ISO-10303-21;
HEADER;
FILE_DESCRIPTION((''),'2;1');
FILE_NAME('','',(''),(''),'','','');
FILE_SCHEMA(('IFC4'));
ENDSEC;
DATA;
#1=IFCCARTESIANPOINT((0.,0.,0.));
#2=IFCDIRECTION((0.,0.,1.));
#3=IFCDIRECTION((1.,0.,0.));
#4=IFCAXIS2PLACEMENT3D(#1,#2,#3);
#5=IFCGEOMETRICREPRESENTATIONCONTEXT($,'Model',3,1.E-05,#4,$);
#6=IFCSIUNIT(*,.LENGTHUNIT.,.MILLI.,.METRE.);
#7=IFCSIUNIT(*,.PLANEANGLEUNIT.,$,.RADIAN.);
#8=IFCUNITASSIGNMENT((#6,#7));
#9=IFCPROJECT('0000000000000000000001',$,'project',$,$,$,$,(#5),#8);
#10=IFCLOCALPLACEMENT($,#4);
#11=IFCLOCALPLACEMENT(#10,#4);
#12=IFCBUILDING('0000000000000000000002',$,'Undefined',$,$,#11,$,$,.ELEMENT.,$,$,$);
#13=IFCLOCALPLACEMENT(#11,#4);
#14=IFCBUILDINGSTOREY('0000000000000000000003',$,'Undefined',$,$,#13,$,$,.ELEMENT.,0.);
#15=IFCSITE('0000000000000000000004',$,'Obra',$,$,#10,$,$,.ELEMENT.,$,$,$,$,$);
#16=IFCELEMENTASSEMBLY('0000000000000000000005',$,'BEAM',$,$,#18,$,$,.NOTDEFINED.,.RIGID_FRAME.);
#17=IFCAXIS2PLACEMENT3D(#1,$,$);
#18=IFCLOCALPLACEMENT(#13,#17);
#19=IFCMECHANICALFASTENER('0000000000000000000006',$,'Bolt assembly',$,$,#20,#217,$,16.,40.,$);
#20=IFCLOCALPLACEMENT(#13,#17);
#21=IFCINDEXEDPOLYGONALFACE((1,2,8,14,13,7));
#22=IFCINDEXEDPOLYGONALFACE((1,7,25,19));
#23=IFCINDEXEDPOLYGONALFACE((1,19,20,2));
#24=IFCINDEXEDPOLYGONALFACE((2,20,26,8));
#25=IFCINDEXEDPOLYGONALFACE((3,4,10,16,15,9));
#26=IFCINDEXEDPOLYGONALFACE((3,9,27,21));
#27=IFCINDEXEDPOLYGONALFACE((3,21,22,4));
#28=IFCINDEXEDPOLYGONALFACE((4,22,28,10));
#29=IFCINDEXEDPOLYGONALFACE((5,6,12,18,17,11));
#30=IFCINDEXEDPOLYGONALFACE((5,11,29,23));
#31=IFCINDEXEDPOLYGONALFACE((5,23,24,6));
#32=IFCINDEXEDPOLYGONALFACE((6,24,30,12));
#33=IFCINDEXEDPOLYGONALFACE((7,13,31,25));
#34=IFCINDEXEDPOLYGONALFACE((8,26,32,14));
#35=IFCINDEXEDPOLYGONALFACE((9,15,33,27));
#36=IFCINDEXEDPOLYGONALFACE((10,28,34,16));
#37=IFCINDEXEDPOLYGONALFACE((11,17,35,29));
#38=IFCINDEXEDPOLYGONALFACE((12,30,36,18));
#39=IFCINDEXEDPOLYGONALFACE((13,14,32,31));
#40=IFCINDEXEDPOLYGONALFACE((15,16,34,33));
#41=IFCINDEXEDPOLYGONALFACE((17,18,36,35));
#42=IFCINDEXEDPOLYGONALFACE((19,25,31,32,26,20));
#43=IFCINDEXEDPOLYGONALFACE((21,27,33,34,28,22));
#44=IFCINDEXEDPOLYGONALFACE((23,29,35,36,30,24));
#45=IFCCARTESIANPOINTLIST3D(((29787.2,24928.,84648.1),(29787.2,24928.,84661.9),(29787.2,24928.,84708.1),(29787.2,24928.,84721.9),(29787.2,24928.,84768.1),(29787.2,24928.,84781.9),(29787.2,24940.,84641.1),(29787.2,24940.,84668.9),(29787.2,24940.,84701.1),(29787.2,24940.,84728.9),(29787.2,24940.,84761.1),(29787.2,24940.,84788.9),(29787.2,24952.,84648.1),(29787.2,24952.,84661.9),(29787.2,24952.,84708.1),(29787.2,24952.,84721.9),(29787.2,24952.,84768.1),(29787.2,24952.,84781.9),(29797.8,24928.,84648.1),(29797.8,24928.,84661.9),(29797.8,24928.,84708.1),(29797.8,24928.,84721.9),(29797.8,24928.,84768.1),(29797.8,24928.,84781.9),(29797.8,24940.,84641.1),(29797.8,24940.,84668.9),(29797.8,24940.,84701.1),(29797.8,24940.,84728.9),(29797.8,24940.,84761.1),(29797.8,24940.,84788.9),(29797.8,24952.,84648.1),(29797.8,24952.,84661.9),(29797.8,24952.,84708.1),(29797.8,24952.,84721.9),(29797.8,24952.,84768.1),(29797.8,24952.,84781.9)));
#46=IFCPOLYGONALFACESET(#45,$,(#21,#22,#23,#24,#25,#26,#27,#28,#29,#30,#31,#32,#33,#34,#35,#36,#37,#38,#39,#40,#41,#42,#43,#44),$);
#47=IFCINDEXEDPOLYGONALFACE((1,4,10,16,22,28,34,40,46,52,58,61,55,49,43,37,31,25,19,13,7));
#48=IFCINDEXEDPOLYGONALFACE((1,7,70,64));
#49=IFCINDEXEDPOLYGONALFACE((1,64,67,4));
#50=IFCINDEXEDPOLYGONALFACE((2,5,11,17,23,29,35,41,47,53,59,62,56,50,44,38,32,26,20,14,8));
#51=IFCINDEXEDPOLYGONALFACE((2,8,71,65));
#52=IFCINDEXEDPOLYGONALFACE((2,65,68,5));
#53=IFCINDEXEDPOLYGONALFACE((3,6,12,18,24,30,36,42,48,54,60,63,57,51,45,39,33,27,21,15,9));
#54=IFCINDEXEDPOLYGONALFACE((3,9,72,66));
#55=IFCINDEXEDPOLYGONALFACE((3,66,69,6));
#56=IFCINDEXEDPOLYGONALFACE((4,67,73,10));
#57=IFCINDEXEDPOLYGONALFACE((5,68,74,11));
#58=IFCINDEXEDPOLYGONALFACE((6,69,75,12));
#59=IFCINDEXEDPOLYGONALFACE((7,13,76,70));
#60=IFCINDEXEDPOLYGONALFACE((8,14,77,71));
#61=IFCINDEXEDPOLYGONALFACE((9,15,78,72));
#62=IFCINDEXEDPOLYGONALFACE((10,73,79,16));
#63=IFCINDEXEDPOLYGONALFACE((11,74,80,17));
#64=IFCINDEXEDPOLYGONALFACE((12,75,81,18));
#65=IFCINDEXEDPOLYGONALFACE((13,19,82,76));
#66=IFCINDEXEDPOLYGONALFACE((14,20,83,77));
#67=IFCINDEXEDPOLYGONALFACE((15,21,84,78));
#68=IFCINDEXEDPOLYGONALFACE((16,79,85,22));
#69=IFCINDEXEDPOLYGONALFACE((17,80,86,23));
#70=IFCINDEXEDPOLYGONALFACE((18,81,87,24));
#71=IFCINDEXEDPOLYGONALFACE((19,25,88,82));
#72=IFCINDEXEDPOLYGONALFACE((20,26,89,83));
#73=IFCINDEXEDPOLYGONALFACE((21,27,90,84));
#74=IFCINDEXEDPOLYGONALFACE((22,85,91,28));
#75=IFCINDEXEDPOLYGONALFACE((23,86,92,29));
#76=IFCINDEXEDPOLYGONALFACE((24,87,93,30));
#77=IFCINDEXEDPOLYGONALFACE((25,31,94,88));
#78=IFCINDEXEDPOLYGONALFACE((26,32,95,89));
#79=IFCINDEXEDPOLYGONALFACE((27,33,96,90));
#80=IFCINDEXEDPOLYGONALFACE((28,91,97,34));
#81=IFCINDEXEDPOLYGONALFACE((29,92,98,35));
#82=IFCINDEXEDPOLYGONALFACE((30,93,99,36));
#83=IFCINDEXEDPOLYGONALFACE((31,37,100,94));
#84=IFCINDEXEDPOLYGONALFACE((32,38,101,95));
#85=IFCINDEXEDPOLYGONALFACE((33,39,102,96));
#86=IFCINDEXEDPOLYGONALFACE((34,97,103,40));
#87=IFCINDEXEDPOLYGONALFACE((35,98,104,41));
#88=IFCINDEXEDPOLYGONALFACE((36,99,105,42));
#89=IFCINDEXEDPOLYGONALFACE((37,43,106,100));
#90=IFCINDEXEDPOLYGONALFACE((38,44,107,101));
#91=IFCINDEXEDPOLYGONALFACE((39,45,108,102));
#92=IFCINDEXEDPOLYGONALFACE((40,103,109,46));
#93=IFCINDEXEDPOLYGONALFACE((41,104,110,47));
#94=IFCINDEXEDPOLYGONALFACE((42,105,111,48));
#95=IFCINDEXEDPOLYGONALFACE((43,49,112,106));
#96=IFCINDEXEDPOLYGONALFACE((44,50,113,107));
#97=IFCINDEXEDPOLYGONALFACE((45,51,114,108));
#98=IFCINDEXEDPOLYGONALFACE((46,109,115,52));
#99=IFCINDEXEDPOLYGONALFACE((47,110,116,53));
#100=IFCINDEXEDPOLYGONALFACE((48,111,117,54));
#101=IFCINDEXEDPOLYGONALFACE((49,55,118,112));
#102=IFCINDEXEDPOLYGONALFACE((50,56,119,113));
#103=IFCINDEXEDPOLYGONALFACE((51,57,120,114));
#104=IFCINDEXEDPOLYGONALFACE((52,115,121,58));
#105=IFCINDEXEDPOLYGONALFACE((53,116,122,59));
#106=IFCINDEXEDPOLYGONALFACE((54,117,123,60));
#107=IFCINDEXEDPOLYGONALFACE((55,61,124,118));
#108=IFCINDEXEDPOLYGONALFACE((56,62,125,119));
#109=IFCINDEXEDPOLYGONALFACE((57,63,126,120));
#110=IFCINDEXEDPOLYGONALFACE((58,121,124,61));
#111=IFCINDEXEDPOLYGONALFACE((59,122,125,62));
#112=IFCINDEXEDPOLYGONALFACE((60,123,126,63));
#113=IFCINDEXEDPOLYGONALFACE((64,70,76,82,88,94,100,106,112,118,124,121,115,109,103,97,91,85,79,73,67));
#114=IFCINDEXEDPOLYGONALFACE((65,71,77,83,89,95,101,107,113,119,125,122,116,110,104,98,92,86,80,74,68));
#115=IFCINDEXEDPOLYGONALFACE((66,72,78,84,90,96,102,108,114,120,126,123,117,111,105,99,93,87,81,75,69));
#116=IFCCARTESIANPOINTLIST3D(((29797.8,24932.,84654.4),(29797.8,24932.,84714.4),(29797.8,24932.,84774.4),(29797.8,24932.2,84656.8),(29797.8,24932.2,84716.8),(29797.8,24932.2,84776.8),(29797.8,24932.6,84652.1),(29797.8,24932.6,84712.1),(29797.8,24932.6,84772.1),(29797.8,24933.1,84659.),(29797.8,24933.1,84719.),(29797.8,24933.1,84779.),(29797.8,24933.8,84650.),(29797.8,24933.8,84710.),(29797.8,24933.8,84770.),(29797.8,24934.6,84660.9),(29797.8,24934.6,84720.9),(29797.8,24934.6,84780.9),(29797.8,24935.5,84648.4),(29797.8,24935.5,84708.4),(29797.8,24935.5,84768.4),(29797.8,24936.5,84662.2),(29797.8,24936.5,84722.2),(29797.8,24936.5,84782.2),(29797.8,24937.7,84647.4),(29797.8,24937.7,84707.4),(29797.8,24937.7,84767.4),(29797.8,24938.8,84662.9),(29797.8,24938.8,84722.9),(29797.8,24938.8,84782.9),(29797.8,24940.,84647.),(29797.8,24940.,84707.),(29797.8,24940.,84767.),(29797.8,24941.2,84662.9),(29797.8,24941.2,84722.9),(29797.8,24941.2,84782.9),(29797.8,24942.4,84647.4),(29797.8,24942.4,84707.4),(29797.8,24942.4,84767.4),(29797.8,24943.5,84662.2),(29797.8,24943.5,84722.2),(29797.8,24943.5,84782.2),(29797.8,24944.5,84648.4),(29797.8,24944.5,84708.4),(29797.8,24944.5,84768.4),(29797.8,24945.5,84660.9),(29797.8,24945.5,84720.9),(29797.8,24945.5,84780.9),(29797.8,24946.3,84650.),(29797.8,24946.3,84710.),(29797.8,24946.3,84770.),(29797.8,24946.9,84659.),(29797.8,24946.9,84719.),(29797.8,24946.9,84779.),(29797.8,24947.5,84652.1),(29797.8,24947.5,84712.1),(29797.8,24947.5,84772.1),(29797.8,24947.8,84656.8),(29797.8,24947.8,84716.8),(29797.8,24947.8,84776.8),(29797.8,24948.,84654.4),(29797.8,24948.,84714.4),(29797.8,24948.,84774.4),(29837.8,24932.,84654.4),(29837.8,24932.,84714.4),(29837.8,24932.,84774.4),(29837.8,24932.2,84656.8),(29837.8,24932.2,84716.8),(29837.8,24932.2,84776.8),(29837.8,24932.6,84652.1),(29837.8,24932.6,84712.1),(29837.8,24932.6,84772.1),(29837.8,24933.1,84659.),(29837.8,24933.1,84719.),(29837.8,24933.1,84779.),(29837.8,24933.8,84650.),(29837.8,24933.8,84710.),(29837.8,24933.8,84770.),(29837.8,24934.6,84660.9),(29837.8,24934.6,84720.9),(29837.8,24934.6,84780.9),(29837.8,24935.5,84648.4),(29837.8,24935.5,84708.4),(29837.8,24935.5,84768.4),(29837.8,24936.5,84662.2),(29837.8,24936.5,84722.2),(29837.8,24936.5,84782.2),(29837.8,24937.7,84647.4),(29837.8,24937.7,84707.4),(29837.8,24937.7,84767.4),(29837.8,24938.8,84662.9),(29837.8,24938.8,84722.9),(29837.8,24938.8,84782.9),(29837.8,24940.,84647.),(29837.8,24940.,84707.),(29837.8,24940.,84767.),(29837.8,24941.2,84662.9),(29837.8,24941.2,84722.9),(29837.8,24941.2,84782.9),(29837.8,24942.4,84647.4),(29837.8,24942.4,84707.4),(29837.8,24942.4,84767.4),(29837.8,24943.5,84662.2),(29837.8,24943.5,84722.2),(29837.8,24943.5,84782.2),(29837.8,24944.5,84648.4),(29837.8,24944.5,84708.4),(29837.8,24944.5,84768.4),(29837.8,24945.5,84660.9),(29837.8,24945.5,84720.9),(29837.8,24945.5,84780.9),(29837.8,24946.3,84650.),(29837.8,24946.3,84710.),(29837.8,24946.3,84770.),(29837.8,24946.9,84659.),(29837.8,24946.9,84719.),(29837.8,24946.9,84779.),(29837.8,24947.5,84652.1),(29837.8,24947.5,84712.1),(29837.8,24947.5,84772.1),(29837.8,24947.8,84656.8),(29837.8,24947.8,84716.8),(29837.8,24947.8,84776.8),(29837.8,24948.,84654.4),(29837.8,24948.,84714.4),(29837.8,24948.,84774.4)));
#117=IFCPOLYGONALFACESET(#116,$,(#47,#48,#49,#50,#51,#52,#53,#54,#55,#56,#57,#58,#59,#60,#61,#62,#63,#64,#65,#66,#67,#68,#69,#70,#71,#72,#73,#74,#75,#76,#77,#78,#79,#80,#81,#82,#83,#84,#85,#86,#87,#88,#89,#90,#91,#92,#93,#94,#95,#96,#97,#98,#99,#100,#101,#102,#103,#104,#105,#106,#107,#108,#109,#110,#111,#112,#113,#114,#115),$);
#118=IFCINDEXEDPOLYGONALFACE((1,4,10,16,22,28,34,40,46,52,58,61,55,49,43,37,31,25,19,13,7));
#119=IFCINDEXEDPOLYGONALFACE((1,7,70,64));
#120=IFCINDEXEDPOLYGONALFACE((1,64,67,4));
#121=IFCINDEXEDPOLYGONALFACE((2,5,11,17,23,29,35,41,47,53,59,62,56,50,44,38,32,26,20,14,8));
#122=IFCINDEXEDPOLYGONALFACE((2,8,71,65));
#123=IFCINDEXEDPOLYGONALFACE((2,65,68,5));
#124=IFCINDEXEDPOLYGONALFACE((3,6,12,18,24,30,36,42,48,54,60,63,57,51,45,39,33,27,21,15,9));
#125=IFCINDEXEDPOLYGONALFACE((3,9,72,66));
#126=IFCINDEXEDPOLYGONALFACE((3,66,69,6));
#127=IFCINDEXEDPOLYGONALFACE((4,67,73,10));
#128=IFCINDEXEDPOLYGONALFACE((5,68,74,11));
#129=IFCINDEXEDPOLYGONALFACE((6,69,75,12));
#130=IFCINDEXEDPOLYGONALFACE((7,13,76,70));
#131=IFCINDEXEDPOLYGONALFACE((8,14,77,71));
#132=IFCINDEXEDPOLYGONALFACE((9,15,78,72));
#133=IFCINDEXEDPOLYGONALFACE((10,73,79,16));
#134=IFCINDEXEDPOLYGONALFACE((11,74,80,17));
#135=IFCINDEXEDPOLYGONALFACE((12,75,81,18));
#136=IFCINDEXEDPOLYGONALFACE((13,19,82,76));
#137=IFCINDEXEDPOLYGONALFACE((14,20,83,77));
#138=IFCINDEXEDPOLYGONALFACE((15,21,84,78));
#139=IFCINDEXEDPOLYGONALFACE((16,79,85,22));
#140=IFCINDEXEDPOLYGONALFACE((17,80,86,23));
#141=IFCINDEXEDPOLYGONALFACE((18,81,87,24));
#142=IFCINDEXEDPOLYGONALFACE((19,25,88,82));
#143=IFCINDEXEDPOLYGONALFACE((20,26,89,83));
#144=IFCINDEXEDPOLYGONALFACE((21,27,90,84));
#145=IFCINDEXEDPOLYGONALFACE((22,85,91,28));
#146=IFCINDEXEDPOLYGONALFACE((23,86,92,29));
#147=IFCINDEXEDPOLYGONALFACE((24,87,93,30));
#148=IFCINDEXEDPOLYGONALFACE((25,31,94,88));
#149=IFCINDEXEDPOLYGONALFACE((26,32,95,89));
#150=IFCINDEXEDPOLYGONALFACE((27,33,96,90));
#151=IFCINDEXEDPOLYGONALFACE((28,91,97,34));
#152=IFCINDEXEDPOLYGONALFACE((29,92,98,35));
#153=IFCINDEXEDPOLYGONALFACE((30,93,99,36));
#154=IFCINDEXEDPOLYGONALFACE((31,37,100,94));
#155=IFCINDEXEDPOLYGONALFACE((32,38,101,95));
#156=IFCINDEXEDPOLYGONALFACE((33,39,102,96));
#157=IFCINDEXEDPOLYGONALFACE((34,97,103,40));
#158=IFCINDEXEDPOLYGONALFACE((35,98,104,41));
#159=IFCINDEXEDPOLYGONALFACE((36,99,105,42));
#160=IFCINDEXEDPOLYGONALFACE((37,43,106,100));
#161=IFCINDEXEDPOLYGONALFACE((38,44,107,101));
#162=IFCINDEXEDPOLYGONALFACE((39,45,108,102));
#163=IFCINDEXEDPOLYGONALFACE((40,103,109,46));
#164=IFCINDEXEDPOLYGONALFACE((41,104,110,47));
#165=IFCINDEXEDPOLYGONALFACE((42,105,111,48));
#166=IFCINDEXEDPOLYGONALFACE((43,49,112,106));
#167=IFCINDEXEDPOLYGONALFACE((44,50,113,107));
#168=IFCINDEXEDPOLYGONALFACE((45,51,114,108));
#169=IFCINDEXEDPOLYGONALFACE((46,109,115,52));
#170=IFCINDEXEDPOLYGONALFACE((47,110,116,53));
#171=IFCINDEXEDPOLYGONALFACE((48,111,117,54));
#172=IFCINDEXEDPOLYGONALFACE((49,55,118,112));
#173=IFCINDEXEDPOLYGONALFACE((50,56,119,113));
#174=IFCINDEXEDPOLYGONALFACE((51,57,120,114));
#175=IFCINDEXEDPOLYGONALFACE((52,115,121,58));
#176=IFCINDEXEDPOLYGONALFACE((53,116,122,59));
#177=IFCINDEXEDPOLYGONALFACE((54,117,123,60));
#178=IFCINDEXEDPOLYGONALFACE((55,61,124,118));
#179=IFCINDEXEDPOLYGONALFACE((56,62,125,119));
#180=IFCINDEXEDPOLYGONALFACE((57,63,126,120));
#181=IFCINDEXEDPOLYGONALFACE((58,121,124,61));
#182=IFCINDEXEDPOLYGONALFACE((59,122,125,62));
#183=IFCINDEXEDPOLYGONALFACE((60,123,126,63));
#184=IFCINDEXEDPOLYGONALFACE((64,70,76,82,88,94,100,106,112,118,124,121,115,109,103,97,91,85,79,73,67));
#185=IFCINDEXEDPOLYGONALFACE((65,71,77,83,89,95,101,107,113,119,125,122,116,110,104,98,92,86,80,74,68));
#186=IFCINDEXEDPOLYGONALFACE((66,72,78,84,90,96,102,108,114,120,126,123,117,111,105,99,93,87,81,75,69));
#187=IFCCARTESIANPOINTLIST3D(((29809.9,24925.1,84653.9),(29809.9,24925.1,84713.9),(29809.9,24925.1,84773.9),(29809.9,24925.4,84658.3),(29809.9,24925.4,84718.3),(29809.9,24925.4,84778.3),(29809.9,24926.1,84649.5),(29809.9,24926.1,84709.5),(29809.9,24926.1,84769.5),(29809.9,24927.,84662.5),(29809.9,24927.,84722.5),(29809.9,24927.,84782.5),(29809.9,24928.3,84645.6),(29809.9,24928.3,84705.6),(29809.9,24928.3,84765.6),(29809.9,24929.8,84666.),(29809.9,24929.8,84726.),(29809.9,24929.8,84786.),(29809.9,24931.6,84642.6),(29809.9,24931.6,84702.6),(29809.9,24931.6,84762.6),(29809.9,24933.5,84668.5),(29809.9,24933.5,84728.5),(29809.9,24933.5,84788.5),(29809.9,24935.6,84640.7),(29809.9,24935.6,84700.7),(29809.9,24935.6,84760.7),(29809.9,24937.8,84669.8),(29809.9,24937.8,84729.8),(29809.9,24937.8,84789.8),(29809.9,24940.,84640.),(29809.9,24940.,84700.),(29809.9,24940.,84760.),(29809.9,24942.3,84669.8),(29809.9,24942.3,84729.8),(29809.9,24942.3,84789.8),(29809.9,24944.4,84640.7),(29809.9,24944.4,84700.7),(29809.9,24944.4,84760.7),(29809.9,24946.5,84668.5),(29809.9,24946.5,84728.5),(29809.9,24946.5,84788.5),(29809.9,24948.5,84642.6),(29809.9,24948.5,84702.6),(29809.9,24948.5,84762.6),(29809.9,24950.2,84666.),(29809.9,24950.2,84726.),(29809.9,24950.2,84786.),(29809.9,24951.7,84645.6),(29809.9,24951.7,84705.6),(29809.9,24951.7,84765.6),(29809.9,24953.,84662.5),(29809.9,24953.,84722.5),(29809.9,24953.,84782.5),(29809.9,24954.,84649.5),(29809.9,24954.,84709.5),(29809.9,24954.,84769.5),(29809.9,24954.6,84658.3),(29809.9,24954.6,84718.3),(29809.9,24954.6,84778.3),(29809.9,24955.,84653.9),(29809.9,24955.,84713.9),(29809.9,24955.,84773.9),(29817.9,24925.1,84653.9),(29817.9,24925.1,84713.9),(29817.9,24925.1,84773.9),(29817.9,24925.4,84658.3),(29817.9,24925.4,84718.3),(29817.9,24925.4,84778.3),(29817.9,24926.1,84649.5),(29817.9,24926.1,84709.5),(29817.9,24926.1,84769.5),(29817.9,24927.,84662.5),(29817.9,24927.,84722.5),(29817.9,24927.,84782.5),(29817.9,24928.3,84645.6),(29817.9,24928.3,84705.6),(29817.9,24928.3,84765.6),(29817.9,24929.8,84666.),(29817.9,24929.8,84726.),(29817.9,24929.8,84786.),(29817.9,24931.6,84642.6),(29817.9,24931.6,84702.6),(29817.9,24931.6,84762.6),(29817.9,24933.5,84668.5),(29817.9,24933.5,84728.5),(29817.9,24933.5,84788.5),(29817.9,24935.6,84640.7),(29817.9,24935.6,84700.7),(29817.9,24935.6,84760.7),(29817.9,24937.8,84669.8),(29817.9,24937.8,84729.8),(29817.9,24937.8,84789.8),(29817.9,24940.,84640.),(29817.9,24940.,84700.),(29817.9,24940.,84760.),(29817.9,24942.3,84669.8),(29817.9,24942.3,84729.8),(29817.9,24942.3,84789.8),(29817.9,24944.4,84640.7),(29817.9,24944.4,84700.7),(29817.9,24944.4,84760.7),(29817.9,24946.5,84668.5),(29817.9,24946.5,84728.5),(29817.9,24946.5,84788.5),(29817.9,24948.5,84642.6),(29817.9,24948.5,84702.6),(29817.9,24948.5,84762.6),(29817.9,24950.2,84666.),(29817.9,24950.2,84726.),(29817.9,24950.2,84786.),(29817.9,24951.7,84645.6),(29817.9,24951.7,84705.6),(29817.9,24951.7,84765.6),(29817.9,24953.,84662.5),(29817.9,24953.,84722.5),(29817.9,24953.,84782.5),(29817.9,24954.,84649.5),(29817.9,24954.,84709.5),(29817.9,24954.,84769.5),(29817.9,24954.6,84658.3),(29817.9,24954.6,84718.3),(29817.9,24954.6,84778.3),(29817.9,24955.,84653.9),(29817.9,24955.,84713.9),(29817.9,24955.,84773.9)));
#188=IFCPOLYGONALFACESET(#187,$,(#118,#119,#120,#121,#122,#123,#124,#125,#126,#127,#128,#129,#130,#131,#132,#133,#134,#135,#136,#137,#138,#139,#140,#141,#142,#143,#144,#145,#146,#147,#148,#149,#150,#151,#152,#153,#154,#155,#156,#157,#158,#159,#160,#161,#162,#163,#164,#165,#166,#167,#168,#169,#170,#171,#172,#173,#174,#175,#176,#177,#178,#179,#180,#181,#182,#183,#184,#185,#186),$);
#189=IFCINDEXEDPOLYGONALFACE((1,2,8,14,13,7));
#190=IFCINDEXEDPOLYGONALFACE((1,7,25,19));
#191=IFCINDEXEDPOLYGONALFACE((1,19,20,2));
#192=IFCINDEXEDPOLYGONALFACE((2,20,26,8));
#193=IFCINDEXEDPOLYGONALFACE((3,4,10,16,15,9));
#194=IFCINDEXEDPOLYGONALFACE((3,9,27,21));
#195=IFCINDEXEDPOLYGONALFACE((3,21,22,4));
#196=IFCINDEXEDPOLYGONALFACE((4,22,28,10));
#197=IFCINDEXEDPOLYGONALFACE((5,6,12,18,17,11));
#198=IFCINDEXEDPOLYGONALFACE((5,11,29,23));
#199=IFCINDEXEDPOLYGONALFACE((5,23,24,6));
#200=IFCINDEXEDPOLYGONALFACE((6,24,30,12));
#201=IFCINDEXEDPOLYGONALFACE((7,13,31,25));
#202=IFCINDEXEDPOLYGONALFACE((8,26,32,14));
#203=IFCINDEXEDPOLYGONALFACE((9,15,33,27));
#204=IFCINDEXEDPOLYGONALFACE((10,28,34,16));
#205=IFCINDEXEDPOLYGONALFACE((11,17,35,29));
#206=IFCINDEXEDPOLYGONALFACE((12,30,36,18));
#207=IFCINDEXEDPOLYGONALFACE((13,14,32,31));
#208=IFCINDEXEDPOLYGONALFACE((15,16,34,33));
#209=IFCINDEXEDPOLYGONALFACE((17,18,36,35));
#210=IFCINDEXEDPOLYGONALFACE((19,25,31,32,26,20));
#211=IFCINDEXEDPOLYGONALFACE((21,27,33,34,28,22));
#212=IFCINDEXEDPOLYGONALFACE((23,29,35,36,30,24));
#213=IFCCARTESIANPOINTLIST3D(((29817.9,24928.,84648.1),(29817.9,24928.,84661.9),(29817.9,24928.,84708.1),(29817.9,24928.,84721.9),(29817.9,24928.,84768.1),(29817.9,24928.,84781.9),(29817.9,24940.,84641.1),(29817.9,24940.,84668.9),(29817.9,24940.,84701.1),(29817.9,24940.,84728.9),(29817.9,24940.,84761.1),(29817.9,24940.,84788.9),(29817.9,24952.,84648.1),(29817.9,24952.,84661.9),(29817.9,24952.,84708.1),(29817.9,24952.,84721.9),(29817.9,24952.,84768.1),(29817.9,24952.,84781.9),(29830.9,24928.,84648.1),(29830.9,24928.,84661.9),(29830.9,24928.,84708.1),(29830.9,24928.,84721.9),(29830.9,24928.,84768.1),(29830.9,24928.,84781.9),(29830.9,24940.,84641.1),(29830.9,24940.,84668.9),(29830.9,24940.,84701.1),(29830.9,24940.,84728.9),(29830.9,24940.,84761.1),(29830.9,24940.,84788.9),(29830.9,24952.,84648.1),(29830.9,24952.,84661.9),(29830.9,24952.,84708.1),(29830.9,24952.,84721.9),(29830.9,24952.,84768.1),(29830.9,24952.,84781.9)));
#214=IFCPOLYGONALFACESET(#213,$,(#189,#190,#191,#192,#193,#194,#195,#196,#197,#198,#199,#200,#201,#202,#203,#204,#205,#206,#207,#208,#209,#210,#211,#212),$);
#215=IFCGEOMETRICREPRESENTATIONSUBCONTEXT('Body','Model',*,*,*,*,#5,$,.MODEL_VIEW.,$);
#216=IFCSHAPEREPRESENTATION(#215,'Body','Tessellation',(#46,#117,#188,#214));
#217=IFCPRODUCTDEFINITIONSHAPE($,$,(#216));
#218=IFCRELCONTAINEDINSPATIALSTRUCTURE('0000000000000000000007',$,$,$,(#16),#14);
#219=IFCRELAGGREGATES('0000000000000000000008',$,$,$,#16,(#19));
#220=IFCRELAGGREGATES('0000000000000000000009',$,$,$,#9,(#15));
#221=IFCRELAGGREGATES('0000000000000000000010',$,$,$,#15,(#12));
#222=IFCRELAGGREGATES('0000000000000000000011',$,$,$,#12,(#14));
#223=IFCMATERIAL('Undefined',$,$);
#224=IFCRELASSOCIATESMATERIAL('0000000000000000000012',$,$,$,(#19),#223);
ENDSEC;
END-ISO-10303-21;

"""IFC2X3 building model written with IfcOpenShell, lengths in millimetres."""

from ifc_helpers import new_model, si_unit, frame, origin_with_axes, origin_2d_with_axis, place, context, subcontext, project, spatial, polyline, circle, outline, extrude, source, transform, mapped, material, element, aggregate, save


model = new_model("IFC2X3")

# Units and contexts
model_context = context("Model", 3, precision=1e-05, world=origin_with_axes())
body_context = subcontext(model_context, "Body", "Model", "MODEL_VIEW")
ifc_project = project(units=[si_unit("LENGTHUNIT", "METRE", prefix="MILLI"), si_unit("PLANEANGLEUNIT", "RADIAN")], contexts=[model_context])

# Site, building, storey
site_placement = place(None, origin_with_axes())
site = spatial("IfcSite", under=ifc_project, at=site_placement, Name="Obra", CompositionType="ELEMENT")
building_placement = place(site_placement, origin_with_axes())
building = spatial("IfcBuilding", under=site, at=building_placement, Name="Undefined", CompositionType="ELEMENT")
storey_placement = place(building_placement, origin_with_axes())
storey = spatial("IfcBuildingStorey", under=building, at=storey_placement, Name="Undefined", CompositionType="ELEMENT", Elevation=0.0)

# Shared definitions
ifc_material_1 = material(Name="Undefined")

# Element assembly
assembly_1_placement = place(storey_placement, origin_with_axes())
assembly_1 = element("IfcElementAssembly", 1, at=assembly_1_placement, inside=storey, Name="BEAM", AssemblyPlace="NOTDEFINED", PredefinedType="RIGID_FRAME")

# Mechanical fastener
shared_shape_1 = source(origin_with_axes(), body_context, "Body", "SweptSolid", [
    extrude(outline(polyline([(13.9, 0.0), (6.9, 12.0), (-6.9, 12.0), (-13.9, 0.0), (-6.9, -12.0), (6.9, -12.0), (13.9, 0.0)])), frame((0.0, -19.7, 0.0), z_axis=(0.0, 1.0, 0.0), x_axis=(1.0, 0.0, 0.0)), (0.0, 0.0, 1.0), 10.6),
    extrude(circle(Radius=8.0, at=origin_2d_with_axis()), frame((0.0, -9.1, 0.0), z_axis=(0.0, 1.0, 0.0), x_axis=(1.0, 0.0, 0.0)), (0.0, 0.0, 1.0), 40.0),
    extrude(circle(Radius=15.0, at=origin_2d_with_axis()), frame((0.0, 3.0, 0.0), z_axis=(0.0, 1.0, 0.0), x_axis=(1.0, 0.0, 0.0)), (0.0, 0.0, 1.0), 8.0),
    extrude(outline(polyline([(13.9, 0.0), (6.9, 12.0), (-6.9, 12.0), (-13.9, 0.0), (-6.9, -12.0), (6.9, -12.0), (13.9, 0.0)])), frame((0.0, 11.0, 0.0), z_axis=(0.0, 1.0, 0.0), x_axis=(1.0, 0.0, 0.0)), (0.0, 0.0, 1.0), 13.0),
])
mechanical_fastener_1_placement = place(assembly_1_placement, frame((29806.9, 24990.0, 84835.0), z_axis=(0.000002, -1.0, 0.0), x_axis=(0.0, 0.0, -1.0)))
mechanical_fastener_1 = element("IfcMechanicalFastener", 2, at=mechanical_fastener_1_placement, material=ifc_material_1, Name="Bolt assembly", NominalDiameter=16.0, NominalLength=40.0, context=body_context, shape_type="MappedRepresentation", body=[
    mapped(shared_shape_1, transform((60.0, 0.0, 50.0))),
    mapped(shared_shape_1, transform((120.0, 0.0, 50.0))),
    mapped(shared_shape_1, transform((180.0, 0.0, 50.0))),
])
aggregate(assembly_1, [mechanical_fastener_1])

save(model, "model.ifc")
